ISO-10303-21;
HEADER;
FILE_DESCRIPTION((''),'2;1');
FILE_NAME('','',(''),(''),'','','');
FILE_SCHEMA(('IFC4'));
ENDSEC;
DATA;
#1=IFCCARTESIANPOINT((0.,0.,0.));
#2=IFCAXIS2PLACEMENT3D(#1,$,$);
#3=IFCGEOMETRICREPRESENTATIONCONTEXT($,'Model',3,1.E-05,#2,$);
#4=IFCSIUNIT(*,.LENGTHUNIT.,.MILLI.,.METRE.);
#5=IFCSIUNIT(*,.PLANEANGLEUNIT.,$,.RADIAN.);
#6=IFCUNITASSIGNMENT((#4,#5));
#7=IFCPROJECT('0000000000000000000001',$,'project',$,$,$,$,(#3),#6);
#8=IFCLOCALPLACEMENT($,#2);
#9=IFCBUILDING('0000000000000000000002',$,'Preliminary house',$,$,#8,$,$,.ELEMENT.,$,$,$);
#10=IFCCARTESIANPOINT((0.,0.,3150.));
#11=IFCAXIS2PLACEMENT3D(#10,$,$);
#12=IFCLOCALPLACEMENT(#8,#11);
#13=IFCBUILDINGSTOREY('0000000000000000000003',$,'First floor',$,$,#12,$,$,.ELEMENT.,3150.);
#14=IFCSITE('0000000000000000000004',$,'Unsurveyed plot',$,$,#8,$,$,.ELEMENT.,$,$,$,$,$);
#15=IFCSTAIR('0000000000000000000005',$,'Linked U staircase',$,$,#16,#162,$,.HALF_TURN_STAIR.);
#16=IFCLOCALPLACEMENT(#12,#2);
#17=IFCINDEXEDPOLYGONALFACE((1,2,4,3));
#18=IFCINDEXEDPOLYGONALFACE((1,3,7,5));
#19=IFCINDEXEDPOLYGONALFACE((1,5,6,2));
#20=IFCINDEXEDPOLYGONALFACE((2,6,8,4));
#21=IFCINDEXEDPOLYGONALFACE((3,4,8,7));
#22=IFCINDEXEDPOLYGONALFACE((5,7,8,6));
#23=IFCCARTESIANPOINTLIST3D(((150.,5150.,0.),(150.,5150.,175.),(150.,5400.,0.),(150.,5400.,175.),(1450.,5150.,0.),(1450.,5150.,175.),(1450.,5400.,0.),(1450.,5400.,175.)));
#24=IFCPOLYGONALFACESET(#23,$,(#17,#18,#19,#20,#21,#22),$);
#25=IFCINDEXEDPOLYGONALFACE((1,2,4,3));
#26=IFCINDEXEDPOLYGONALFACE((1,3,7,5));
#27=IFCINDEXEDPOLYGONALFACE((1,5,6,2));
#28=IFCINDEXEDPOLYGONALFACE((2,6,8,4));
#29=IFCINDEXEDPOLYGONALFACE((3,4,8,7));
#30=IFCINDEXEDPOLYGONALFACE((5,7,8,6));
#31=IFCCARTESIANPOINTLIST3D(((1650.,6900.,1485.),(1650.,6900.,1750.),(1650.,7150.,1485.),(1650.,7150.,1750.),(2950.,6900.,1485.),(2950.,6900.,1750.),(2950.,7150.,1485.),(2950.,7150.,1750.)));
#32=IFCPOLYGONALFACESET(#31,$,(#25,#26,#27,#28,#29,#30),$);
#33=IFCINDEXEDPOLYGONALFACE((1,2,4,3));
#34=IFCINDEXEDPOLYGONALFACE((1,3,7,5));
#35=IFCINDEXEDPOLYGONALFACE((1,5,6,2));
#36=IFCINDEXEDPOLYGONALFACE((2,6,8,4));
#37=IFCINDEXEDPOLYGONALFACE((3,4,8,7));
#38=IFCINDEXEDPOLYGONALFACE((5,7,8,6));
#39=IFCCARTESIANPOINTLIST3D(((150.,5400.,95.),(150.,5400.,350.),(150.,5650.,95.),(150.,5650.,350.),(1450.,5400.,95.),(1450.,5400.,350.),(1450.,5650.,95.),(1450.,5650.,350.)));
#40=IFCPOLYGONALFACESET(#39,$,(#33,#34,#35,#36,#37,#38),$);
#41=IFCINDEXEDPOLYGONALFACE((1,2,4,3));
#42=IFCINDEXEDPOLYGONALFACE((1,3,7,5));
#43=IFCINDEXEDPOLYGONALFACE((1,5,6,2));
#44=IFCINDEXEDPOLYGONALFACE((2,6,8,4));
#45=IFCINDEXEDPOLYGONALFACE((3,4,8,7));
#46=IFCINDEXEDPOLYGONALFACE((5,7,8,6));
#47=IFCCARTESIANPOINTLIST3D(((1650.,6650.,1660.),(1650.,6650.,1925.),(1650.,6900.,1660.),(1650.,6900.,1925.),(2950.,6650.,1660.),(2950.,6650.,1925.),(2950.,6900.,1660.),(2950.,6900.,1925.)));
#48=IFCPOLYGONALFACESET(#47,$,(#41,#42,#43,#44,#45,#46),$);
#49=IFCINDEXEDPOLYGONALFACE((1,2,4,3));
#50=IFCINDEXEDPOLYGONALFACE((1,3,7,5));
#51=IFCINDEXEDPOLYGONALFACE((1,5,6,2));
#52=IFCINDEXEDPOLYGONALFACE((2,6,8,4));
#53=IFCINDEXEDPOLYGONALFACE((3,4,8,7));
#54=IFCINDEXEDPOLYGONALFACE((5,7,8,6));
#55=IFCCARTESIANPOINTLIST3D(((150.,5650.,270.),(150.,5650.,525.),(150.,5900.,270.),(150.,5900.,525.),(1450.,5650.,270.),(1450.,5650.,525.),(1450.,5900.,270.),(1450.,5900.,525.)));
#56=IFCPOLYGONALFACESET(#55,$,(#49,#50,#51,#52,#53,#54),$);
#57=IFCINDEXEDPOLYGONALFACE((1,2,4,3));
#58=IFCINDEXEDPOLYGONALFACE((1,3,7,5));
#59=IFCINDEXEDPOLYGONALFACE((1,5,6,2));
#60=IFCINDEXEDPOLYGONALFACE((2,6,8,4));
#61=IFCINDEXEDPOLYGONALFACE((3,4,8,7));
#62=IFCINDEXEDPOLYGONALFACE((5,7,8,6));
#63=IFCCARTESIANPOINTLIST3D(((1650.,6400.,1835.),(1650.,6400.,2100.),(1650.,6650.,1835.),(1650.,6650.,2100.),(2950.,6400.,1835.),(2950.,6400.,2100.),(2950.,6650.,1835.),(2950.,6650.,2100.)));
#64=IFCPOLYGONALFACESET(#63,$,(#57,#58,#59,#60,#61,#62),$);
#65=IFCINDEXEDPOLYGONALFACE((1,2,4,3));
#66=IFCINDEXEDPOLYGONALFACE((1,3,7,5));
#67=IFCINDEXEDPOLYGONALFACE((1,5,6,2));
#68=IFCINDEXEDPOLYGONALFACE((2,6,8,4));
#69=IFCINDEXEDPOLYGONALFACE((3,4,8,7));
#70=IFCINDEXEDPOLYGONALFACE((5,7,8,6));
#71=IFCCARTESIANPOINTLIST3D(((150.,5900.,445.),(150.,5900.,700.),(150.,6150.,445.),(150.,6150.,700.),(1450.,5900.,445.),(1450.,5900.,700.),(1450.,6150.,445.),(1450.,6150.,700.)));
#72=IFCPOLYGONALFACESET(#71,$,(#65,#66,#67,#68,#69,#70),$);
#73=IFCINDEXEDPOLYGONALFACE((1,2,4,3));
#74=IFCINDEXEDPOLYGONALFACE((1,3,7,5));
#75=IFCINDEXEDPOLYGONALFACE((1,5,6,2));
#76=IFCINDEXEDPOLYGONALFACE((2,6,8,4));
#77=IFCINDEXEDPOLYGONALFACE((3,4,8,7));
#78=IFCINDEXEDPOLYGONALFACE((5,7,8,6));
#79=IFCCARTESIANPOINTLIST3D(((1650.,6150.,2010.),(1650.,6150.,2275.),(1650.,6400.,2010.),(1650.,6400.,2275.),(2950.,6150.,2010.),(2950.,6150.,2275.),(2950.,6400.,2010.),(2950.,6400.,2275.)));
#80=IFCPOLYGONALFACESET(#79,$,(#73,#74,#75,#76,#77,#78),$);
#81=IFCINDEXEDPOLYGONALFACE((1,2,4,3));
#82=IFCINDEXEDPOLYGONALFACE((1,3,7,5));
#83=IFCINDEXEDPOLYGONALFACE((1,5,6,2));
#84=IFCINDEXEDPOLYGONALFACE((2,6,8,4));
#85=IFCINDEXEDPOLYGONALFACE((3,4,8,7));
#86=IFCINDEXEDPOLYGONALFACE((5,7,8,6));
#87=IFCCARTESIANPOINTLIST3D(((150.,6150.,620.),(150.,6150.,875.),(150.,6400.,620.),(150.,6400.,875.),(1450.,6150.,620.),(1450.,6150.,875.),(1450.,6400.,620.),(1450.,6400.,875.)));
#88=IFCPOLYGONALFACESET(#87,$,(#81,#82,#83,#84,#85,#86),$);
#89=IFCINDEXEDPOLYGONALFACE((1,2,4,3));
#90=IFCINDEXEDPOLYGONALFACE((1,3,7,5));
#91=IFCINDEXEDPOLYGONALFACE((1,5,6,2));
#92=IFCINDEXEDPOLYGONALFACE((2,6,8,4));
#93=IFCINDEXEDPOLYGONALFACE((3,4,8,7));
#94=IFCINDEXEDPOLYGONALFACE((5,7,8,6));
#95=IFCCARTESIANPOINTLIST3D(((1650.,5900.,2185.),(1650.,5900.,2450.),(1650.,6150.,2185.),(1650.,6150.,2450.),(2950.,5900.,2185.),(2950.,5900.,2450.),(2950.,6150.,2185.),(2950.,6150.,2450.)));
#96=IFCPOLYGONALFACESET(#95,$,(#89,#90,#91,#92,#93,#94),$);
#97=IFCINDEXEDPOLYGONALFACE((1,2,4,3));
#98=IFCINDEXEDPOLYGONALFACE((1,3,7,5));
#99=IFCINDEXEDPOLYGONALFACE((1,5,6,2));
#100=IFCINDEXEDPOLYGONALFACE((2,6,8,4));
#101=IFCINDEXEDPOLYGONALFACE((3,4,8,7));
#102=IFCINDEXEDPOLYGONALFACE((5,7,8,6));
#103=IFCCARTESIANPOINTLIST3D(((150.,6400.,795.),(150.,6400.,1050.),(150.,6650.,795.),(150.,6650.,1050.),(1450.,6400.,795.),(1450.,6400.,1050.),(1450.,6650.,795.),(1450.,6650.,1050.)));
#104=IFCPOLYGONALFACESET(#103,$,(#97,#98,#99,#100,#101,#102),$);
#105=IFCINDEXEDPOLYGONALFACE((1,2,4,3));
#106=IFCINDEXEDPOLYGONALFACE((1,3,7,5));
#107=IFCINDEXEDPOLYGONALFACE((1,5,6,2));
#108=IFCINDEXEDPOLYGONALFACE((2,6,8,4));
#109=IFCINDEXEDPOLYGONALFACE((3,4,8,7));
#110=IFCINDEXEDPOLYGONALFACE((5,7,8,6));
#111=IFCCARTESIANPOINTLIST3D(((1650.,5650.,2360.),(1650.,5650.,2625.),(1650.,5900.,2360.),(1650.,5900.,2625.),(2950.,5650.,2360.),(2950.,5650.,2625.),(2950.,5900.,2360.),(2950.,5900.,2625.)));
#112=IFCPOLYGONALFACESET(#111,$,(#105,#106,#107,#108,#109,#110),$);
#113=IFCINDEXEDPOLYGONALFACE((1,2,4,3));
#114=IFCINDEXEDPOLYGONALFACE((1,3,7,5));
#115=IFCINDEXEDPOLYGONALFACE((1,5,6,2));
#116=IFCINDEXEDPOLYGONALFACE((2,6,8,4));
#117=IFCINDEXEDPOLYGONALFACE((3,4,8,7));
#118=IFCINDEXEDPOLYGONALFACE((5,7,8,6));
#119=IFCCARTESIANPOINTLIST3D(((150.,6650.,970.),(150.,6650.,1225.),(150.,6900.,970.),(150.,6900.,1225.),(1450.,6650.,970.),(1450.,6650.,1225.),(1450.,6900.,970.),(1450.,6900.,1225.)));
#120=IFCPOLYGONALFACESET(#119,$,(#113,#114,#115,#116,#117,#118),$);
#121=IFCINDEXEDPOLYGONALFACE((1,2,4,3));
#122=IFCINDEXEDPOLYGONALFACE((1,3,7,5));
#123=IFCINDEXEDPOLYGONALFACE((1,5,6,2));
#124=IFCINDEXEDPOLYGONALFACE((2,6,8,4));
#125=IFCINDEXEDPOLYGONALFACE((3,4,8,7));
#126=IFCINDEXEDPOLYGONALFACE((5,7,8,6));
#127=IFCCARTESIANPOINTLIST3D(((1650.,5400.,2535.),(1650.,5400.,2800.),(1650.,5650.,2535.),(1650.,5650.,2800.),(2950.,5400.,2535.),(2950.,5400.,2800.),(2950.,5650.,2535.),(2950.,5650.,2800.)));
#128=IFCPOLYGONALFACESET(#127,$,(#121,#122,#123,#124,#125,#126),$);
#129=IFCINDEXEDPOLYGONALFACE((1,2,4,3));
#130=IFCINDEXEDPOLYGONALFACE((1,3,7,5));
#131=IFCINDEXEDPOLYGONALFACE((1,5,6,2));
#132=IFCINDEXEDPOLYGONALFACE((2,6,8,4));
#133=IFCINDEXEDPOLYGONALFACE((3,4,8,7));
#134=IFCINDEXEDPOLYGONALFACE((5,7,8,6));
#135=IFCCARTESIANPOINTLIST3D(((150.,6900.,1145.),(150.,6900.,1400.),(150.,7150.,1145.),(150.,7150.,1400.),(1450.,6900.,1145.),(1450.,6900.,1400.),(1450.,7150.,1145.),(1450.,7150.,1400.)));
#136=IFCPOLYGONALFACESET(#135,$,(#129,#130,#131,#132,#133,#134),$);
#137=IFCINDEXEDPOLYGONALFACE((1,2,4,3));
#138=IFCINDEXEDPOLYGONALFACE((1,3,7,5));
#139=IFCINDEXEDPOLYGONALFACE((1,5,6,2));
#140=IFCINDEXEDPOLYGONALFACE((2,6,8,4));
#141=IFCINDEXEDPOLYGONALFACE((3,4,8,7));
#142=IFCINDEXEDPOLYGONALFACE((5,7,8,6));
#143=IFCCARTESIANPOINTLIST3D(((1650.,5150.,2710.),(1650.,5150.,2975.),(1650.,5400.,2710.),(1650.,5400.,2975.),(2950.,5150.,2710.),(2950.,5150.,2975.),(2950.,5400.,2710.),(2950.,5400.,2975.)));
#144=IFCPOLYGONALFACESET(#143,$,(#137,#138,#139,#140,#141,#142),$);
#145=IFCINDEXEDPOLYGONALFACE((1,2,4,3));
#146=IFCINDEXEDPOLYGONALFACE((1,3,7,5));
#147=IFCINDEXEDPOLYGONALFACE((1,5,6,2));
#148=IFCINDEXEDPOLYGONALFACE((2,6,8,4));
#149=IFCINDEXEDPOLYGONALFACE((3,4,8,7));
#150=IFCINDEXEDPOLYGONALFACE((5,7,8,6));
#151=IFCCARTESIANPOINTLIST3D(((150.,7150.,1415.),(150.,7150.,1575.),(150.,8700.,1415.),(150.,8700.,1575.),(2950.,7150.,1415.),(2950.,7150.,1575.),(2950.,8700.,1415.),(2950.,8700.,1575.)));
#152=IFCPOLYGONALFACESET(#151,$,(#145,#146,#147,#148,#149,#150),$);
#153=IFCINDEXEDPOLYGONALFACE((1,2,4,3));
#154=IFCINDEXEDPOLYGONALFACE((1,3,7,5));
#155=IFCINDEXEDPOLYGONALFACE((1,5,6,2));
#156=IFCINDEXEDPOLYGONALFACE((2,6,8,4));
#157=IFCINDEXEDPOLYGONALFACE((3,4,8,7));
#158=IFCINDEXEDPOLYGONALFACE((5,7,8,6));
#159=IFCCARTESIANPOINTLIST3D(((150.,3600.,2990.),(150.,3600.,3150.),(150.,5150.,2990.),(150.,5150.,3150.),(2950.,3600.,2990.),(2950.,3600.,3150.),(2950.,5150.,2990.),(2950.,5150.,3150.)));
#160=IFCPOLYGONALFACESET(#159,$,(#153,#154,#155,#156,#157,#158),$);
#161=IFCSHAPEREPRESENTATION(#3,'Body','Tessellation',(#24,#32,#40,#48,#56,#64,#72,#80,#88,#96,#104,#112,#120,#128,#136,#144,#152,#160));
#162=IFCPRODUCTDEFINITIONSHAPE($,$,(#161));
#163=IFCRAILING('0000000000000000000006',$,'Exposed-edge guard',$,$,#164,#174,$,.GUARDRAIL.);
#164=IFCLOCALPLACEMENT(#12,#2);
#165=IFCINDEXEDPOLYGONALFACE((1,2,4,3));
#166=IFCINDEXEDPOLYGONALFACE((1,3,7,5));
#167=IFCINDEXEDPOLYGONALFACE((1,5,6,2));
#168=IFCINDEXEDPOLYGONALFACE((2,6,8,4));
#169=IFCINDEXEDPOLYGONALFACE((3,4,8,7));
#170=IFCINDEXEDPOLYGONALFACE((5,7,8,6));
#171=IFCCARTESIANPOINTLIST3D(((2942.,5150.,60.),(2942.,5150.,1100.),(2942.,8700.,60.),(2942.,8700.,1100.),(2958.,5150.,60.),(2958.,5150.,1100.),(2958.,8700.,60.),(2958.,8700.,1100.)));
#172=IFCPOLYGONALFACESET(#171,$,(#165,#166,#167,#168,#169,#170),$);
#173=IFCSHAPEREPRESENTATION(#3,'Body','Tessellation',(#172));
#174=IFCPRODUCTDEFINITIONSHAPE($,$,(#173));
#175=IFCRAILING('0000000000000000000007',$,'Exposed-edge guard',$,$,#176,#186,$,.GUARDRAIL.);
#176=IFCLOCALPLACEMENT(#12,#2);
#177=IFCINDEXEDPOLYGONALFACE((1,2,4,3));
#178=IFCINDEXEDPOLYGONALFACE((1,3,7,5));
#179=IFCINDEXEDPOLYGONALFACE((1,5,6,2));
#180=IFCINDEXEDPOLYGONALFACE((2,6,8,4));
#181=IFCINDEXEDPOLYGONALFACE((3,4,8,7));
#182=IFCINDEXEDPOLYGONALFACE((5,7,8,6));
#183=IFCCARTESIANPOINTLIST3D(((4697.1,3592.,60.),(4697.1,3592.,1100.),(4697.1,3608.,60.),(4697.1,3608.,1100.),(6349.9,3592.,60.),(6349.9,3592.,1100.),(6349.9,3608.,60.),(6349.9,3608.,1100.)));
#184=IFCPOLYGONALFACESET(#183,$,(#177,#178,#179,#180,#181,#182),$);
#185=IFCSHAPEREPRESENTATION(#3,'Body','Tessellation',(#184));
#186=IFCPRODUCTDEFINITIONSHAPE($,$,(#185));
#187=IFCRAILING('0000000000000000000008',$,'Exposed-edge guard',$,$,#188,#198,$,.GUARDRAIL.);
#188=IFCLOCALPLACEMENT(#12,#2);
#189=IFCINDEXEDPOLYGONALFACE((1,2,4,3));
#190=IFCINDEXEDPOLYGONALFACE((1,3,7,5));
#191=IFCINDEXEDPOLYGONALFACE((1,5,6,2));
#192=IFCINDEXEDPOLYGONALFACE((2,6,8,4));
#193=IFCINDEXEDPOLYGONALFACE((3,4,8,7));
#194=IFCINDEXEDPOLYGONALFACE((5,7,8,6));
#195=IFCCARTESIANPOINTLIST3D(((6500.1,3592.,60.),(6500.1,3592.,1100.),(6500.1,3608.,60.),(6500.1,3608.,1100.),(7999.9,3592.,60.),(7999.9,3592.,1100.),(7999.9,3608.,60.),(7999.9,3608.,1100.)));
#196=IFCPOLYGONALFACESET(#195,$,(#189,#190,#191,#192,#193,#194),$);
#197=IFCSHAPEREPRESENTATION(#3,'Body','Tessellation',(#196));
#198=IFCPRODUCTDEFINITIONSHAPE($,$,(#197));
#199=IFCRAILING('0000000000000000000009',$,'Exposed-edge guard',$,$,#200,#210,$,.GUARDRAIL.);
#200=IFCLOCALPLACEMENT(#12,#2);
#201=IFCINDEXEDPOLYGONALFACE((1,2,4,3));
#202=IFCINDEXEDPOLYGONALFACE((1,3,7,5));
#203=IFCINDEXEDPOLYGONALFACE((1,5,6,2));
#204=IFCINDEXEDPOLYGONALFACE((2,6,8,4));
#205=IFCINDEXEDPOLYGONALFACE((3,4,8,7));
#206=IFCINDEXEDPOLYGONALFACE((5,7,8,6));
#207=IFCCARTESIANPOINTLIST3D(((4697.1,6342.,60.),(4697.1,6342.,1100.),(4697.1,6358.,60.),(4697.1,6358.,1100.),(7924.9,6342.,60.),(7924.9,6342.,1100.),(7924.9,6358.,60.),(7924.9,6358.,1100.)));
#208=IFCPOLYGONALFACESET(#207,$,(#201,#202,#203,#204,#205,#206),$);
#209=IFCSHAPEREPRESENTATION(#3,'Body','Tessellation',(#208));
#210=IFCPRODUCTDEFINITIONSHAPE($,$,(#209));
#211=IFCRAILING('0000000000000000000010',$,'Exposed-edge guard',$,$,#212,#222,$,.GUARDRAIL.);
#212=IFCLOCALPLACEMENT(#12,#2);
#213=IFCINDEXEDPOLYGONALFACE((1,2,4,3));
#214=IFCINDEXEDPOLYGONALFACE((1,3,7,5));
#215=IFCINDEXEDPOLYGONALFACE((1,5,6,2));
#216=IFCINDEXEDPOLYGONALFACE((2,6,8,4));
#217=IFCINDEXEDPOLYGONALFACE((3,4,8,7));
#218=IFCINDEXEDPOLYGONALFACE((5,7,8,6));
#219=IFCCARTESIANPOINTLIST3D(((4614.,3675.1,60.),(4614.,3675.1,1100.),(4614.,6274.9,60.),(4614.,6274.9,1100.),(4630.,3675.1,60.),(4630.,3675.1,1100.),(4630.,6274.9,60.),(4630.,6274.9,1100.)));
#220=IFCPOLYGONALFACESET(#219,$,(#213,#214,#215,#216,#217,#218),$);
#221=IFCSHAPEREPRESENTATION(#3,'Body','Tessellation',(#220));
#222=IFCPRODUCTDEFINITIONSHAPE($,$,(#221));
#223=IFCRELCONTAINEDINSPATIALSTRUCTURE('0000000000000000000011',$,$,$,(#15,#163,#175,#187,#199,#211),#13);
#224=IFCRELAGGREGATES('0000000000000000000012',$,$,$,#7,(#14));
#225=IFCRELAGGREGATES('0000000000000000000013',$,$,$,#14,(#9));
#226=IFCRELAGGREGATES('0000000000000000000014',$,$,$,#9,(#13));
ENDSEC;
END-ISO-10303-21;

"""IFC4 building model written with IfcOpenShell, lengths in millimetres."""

from ifc_helpers import new_model, si_unit, frame, origin, place, context, project, spatial, polyline, outline, extrude, element, save


model = new_model("IFC4")

# Units and contexts
model_context = context("Model", 3, precision=1e-05, world=origin())
ifc_project = project(units=[si_unit("LENGTHUNIT", "METRE", prefix="MILLI"), si_unit("PLANEANGLEUNIT", "RADIAN")], contexts=[model_context])

# Site, building, storey
placement_1 = place(None, origin())
site = spatial("IfcSite", under=ifc_project, at=placement_1, Name="Unsurveyed plot", CompositionType="ELEMENT")
building = spatial("IfcBuilding", under=site, at=placement_1, Name="Preliminary house", CompositionType="ELEMENT")
placement_2 = place(placement_1, frame((0.0, 0.0, 3150.0)))
storey = spatial("IfcBuildingStorey", under=building, at=placement_2, Name="First floor", CompositionType="ELEMENT", Elevation=3150.0)

# Stair
element("IfcStair", 1, at=placement_2, inside=storey, Name="Linked U staircase", PredefinedType="HALF_TURN_STAIR", context=model_context, shape_type="SweptSolid", body=[
    extrude(outline(polyline([(1450.0, 5150.0), (1450.0, 5400.0), (150.0, 5400.0), (150.0, 5150.0), (1450.0, 5150.0)])), origin(), (0.0, 0.0, 1.0), 175.0),
    extrude(outline(polyline([(2950.0, 6900.0), (2950.0, 7150.0), (1650.0, 7150.0), (1650.0, 6900.0), (2950.0, 6900.0)])), frame((0.0, 0.0, 1485.0)), (0.0, 0.0, 1.0), 265.0),
    extrude(outline(polyline([(1450.0, 5400.0), (1450.0, 5650.0), (150.0, 5650.0), (150.0, 5400.0), (1450.0, 5400.0)])), frame((0.0, 0.0, 95.0)), (0.0, 0.0, 1.0), 255.0),
    extrude(outline(polyline([(2950.0, 6650.0), (2950.0, 6900.0), (1650.0, 6900.0), (1650.0, 6650.0), (2950.0, 6650.0)])), frame((0.0, 0.0, 1660.0)), (0.0, 0.0, 1.0), 265.0),
    extrude(outline(polyline([(1450.0, 5650.0), (1450.0, 5900.0), (150.0, 5900.0), (150.0, 5650.0), (1450.0, 5650.0)])), frame((0.0, 0.0, 270.0)), (0.0, 0.0, 1.0), 255.0),
    extrude(outline(polyline([(2950.0, 6400.0), (2950.0, 6650.0), (1650.0, 6650.0), (1650.0, 6400.0), (2950.0, 6400.0)])), frame((0.0, 0.0, 1835.0)), (0.0, 0.0, 1.0), 265.0),
    extrude(outline(polyline([(1450.0, 5900.0), (1450.0, 6150.0), (150.0, 6150.0), (150.0, 5900.0), (1450.0, 5900.0)])), frame((0.0, 0.0, 445.0)), (0.0, 0.0, 1.0), 255.0),
    extrude(outline(polyline([(2950.0, 6150.0), (2950.0, 6400.0), (1650.0, 6400.0), (1650.0, 6150.0), (2950.0, 6150.0)])), frame((0.0, 0.0, 2010.0)), (0.0, 0.0, 1.0), 265.0),
    extrude(outline(polyline([(1450.0, 6150.0), (1450.0, 6400.0), (150.0, 6400.0), (150.0, 6150.0), (1450.0, 6150.0)])), frame((0.0, 0.0, 620.0)), (0.0, 0.0, 1.0), 255.0),
    extrude(outline(polyline([(2950.0, 5900.0), (2950.0, 6150.0), (1650.0, 6150.0), (1650.0, 5900.0), (2950.0, 5900.0)])), frame((0.0, 0.0, 2185.0)), (0.0, 0.0, 1.0), 265.0),
    extrude(outline(polyline([(1450.0, 6400.0), (1450.0, 6650.0), (150.0, 6650.0), (150.0, 6400.0), (1450.0, 6400.0)])), frame((0.0, 0.0, 795.0)), (0.0, 0.0, 1.0), 255.0),
    extrude(outline(polyline([(2950.0, 5650.0), (2950.0, 5900.0), (1650.0, 5900.0), (1650.0, 5650.0), (2950.0, 5650.0)])), frame((0.0, 0.0, 2360.0)), (0.0, 0.0, 1.0), 265.0),
    extrude(outline(polyline([(1450.0, 6650.0), (1450.0, 6900.0), (150.0, 6900.0), (150.0, 6650.0), (1450.0, 6650.0)])), frame((0.0, 0.0, 970.0)), (0.0, 0.0, 1.0), 255.0),
    extrude(outline(polyline([(2950.0, 5400.0), (2950.0, 5650.0), (1650.0, 5650.0), (1650.0, 5400.0), (2950.0, 5400.0)])), frame((0.0, 0.0, 2535.0)), (0.0, 0.0, 1.0), 265.0),
    extrude(outline(polyline([(1450.0, 6900.0), (1450.0, 7150.0), (150.0, 7150.0), (150.0, 6900.0), (1450.0, 6900.0)])), frame((0.0, 0.0, 1145.0)), (0.0, 0.0, 1.0), 255.0),
    extrude(outline(polyline([(2950.0, 5150.0), (2950.0, 5400.0), (1650.0, 5400.0), (1650.0, 5150.0), (2950.0, 5150.0)])), frame((0.0, 0.0, 2710.0)), (0.0, 0.0, 1.0), 265.0),
    extrude(outline(polyline([(2950.0, 7150.0), (2950.0, 8700.0), (150.0, 8700.0), (150.0, 7150.0), (2950.0, 7150.0)])), frame((0.0, 0.0, 1415.0)), (0.0, 0.0, 1.0), 160.0),
    extrude(outline(polyline([(2950.0, 3600.0), (2950.0, 5150.0), (150.0, 5150.0), (150.0, 3600.0), (2950.0, 3600.0)])), frame((0.0, 0.0, 2990.0)), (0.0, 0.0, 1.0), 160.0),
])

# Railings
element("IfcRailing", 2, at=placement_2, inside=storey, Name="Exposed-edge guard", PredefinedType="GUARDRAIL", context=model_context, shape_type="SweptSolid", body=[
    extrude(outline(polyline([(2942.0, 8700.0), (2958.0, 8700.0), (2958.0, 5150.0), (2942.0, 5150.0), (2942.0, 8700.0)])), frame((0.0, 0.0, 60.0)), (0.0, 0.0, 1.0), 1040.0),
])
element("IfcRailing", 3, at=placement_2, inside=storey, Name="Exposed-edge guard", PredefinedType="GUARDRAIL", context=model_context, shape_type="SweptSolid", body=[
    extrude(outline(polyline([(6349.9, 3608.0), (6349.9, 3592.0), (4697.1, 3592.0), (4697.1, 3608.0), (6349.9, 3608.0)])), frame((0.0, 0.0, 60.0)), (0.0, 0.0, 1.0), 1040.0),
])
element("IfcRailing", 4, at=placement_2, inside=storey, Name="Exposed-edge guard", PredefinedType="GUARDRAIL", context=model_context, shape_type="SweptSolid", body=[
    extrude(outline(polyline([(7999.9, 3608.0), (7999.9, 3592.0), (6500.1, 3592.0), (6500.1, 3608.0), (7999.9, 3608.0)])), frame((0.0, 0.0, 60.0)), (0.0, 0.0, 1.0), 1040.0),
])
element("IfcRailing", 5, at=placement_2, inside=storey, Name="Exposed-edge guard", PredefinedType="GUARDRAIL", context=model_context, shape_type="SweptSolid", body=[
    extrude(outline(polyline([(4697.1, 6342.0), (4697.1, 6358.0), (7924.9, 6358.0), (7924.9, 6342.0), (4697.1, 6342.0)])), frame((0.0, 0.0, 60.0)), (0.0, 0.0, 1.0), 1040.0),
])
element("IfcRailing", 6, at=placement_2, inside=storey, Name="Exposed-edge guard", PredefinedType="GUARDRAIL", context=model_context, shape_type="SweptSolid", body=[
    extrude(outline(polyline([(4630.0, 3675.1), (4614.0, 3675.1), (4614.0, 6274.9), (4630.0, 6274.9), (4630.0, 3675.1)])), frame((0.0, 0.0, 60.0)), (0.0, 0.0, 1.0), 1040.0),
])

save(model, "model.ifc")
